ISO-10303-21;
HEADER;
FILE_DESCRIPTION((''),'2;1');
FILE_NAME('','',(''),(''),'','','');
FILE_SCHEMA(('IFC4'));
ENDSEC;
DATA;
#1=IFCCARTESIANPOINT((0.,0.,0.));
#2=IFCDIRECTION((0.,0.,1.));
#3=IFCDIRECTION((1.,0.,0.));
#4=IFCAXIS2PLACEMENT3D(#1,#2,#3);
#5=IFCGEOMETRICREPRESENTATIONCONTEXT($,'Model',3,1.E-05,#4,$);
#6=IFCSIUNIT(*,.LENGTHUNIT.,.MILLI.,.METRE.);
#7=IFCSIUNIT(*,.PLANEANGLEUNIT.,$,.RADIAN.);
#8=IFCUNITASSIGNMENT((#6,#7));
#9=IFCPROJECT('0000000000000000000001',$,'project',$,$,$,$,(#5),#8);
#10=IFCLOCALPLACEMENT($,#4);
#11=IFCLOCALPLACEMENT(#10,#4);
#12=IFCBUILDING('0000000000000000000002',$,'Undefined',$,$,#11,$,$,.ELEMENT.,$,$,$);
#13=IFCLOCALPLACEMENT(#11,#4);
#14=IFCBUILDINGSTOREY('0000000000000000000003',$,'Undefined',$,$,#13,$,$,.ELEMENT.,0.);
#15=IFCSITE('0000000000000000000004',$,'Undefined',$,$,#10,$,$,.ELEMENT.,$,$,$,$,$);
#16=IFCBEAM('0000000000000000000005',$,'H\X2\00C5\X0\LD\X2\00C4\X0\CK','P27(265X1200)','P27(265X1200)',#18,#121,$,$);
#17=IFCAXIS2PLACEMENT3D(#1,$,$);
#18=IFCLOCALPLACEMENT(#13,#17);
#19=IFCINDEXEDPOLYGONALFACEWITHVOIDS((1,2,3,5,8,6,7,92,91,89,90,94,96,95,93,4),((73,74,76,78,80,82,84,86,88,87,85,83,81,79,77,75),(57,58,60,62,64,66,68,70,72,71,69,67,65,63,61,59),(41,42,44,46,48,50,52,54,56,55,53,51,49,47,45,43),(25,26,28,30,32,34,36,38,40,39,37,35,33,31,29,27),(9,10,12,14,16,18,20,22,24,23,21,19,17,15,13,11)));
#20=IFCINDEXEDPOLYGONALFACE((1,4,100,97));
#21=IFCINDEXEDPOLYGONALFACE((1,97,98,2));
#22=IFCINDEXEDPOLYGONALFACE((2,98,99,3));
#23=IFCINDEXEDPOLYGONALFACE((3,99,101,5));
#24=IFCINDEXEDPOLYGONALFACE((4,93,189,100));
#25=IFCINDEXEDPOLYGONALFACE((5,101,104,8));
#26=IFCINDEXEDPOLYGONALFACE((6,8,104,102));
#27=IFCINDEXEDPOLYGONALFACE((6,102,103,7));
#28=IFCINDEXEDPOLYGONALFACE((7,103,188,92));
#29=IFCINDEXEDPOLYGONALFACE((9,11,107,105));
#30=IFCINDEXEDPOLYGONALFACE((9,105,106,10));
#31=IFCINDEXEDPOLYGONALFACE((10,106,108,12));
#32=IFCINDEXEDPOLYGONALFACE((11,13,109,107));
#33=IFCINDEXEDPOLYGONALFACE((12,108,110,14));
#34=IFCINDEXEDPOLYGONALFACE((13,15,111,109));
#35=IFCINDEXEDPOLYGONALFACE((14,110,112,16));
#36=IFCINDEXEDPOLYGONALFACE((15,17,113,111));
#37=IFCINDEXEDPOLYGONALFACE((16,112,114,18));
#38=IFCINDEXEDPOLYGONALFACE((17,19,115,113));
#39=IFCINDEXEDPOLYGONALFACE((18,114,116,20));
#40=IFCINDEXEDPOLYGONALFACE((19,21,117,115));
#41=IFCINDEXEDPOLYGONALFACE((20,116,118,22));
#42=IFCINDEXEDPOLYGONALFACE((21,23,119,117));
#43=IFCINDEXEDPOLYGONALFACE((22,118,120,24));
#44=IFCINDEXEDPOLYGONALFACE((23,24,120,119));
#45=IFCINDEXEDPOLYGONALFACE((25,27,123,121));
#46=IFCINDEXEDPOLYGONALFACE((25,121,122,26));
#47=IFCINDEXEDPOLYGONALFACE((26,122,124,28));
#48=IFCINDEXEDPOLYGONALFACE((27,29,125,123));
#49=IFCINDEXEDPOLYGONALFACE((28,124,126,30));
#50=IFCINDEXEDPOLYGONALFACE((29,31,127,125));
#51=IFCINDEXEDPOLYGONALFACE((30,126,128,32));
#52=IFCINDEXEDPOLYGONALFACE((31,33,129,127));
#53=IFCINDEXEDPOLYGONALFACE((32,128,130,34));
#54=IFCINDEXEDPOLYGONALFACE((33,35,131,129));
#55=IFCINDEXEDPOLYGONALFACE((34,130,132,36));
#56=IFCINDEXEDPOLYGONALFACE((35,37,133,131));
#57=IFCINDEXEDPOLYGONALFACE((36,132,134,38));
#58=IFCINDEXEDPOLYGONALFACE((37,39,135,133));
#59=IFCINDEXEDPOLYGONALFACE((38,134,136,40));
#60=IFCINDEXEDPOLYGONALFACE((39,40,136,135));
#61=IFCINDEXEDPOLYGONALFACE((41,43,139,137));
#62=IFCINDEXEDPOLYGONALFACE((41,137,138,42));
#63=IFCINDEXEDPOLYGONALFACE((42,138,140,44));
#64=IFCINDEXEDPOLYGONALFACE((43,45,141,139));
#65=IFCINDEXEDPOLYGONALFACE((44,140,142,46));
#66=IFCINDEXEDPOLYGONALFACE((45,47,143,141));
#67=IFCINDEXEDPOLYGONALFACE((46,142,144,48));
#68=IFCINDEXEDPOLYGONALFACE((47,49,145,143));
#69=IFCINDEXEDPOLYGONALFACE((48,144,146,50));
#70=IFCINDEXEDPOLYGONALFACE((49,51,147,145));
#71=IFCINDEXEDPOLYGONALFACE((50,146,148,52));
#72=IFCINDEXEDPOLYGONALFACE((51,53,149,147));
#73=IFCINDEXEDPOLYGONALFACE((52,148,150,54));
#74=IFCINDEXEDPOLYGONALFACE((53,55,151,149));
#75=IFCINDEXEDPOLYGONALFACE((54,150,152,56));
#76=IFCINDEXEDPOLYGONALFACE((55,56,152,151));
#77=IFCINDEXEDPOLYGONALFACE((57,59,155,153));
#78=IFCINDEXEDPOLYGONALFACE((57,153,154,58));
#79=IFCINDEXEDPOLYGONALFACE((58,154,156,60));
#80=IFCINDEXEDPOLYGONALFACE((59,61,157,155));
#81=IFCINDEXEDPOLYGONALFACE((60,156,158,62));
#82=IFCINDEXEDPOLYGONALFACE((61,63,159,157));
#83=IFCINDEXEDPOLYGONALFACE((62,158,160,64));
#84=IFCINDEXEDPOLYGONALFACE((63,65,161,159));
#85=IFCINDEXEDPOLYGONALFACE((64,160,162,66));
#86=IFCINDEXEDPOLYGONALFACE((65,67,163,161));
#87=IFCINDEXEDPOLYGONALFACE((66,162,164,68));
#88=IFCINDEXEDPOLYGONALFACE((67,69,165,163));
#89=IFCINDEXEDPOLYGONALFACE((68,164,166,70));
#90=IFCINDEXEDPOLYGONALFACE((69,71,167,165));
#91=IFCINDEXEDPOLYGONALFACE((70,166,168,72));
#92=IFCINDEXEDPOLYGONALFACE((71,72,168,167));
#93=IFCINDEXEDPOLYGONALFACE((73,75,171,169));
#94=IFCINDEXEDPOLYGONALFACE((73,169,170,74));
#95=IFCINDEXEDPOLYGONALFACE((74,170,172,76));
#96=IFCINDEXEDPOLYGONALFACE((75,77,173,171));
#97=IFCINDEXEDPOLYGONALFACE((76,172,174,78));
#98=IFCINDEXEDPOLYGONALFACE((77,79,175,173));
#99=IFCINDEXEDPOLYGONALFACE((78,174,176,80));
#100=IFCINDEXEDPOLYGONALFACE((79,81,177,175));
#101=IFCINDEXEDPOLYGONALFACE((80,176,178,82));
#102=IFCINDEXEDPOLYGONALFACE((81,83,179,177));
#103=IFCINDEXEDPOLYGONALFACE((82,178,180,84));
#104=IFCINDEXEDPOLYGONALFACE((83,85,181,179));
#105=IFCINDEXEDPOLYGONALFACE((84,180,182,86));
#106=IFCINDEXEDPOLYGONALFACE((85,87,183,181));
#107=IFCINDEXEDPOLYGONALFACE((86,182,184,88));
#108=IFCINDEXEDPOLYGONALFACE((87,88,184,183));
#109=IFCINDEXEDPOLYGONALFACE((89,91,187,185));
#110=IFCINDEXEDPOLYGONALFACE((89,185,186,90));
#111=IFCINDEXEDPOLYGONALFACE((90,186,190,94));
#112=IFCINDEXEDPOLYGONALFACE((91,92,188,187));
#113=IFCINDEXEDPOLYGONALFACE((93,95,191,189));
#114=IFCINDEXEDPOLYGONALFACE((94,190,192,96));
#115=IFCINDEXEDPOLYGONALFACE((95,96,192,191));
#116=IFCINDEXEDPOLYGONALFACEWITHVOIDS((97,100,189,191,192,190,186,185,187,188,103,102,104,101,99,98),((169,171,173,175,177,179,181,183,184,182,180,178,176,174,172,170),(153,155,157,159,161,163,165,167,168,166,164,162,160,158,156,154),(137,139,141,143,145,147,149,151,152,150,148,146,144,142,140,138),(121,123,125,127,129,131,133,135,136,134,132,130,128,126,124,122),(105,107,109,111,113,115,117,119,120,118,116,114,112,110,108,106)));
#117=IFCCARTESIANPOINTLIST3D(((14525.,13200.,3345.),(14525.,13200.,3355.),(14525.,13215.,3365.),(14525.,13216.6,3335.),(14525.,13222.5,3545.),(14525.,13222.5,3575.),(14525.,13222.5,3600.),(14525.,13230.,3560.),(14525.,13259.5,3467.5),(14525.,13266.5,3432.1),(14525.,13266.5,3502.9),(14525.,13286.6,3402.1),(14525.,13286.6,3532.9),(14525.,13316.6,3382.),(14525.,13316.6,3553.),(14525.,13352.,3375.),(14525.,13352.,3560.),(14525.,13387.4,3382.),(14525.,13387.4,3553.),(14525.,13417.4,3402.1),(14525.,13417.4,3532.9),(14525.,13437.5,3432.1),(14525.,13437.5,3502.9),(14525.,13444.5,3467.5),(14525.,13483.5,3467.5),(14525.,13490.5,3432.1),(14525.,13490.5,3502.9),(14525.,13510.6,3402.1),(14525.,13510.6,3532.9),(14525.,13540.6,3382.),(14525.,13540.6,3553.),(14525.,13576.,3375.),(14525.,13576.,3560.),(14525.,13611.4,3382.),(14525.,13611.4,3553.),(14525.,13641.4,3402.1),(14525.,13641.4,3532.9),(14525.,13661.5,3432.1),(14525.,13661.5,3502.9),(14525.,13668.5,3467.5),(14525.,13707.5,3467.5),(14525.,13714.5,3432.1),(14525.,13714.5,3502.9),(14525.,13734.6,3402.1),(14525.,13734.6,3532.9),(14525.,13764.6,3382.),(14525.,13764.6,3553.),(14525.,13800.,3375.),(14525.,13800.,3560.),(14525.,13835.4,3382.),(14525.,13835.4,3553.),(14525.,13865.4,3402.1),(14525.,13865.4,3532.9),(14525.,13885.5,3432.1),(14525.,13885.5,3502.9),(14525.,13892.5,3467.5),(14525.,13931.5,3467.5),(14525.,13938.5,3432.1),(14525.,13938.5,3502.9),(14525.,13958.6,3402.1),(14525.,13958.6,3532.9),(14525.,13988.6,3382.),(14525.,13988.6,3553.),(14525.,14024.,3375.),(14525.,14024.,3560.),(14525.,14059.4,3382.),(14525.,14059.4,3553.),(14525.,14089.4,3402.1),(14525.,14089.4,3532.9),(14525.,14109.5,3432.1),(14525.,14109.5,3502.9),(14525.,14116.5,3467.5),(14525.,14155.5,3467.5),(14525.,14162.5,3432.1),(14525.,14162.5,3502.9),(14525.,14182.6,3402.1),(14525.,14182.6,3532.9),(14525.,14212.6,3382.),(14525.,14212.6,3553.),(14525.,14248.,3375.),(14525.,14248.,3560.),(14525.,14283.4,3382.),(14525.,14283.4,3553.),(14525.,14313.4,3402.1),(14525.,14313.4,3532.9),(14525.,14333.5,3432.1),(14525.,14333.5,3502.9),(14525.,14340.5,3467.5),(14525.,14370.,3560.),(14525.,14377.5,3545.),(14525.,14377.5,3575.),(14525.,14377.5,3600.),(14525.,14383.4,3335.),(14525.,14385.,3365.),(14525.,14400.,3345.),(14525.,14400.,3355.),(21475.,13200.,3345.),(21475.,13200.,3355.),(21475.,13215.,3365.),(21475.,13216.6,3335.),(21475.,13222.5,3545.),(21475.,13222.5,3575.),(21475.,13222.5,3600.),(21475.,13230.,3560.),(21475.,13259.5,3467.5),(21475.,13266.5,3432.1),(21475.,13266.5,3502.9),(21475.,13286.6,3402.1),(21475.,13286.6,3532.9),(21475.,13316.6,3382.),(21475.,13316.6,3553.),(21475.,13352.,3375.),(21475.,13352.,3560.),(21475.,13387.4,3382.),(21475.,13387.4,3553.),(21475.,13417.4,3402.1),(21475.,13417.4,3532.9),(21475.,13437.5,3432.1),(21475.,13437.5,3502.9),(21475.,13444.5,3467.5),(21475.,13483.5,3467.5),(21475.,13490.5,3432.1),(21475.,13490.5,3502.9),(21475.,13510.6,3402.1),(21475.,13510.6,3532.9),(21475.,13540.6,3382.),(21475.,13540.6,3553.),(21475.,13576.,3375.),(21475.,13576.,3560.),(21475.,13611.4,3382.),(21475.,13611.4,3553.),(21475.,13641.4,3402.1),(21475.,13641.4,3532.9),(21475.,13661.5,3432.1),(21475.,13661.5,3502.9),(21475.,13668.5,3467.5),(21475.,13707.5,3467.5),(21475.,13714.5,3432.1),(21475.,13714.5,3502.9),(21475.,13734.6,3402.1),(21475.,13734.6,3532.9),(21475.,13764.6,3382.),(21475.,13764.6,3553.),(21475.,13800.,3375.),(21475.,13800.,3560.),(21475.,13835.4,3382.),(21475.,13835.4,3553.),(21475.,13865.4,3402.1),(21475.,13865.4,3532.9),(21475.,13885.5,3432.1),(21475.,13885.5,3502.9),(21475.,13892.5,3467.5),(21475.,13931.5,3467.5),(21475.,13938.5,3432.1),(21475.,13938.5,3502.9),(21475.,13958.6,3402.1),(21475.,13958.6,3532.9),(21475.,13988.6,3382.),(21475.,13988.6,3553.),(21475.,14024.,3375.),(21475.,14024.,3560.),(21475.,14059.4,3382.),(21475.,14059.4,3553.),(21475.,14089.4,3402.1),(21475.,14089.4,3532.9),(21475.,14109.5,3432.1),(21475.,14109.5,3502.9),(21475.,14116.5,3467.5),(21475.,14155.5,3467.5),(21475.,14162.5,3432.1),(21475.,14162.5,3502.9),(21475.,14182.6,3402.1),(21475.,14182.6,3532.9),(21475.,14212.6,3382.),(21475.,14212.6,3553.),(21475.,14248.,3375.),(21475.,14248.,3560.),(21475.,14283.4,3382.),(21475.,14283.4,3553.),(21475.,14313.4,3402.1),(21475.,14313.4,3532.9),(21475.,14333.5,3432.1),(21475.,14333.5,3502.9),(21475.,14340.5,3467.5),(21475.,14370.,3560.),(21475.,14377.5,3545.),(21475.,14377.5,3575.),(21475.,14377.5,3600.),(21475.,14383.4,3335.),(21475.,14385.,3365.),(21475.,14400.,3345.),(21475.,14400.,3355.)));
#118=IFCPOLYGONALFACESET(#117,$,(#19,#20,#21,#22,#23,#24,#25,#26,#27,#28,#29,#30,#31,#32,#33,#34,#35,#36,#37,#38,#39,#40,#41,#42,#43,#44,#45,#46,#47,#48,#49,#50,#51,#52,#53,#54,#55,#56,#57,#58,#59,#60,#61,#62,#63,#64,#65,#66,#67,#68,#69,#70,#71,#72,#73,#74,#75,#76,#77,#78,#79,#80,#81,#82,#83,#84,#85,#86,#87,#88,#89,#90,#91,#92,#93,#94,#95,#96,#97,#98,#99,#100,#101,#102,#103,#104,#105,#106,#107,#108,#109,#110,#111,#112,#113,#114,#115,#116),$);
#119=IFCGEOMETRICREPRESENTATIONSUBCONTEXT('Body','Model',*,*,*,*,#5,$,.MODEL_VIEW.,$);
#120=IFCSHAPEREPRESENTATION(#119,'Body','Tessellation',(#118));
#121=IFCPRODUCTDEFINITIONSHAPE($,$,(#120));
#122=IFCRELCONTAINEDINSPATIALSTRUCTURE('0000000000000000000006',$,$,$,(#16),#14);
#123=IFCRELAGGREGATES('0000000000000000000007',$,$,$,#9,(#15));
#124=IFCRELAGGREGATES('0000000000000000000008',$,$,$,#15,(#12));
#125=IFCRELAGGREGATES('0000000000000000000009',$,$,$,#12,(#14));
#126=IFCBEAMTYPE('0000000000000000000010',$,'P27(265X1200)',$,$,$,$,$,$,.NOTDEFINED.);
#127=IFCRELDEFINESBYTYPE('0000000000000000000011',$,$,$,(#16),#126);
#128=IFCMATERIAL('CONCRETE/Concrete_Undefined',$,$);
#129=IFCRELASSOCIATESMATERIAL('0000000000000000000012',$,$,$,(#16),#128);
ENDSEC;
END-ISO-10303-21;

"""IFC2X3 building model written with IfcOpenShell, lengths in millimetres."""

from ifc_helpers import new_model, si_unit, frame, origin_with_axes, place, context, subcontext, project, spatial, polyline, outline, extrude, material, type_object, element, save


model = new_model("IFC2X3")

# Units and contexts
model_context = context("Model", 3, precision=1e-05, world=origin_with_axes())
body_context = subcontext(model_context, "Body", "Model", "MODEL_VIEW")
ifc_project = project(units=[si_unit("LENGTHUNIT", "METRE", prefix="MILLI"), si_unit("PLANEANGLEUNIT", "RADIAN")], contexts=[model_context])

# Site, building, storey
site_placement = place(None, origin_with_axes())
site = spatial("IfcSite", under=ifc_project, at=site_placement, Name="Undefined", CompositionType="ELEMENT")
building_placement = place(site_placement, origin_with_axes())
building = spatial("IfcBuilding", under=site, at=building_placement, Name="Undefined", CompositionType="ELEMENT")
storey_placement = place(building_placement, origin_with_axes())
storey = spatial("IfcBuildingStorey", under=building, at=storey_placement, Name="Undefined", CompositionType="ELEMENT", Elevation=0.0)

# Beam
ifc_material_1 = material(Name="CONCRETE/Concrete_Undefined")
beam_type_1 = type_object("IfcBeamType", Name="P27(265X1200)", PredefinedType="NOTDEFINED")
beam_1_placement = place(storey_placement, frame((14525.0, 13800.0, 3467.5), z_axis=(0.0, 0.0, 1.0), x_axis=(1.0, 0.0, 0.0)))
element("IfcBeam", 1, at=beam_1_placement, inside=storey, type_object=beam_type_1, material=ifc_material_1, Name="HÅLDÄCK", Description="P27(265X1200)", ObjectType="P27(265X1200)", context=body_context, shape_type="SweptSolid", body=[
    extrude(outline(polyline([(-583.4, -132.5), (-600.0, -122.5), (-600.0, -112.5), (-585.0, -102.5), (-577.5, 77.5), (-570.0, 92.5), (-577.5, 107.5), (-577.5, 132.5), (577.5, 132.5), (577.5, 107.5), (570.0, 92.5), (577.5, 77.5), (585.0, -102.5), (600.0, -112.5), (600.0, -122.5), (583.4, -132.5), (-583.4, -132.5)]), holes=[polyline([(-513.4, 65.4), (-533.5, 35.4), (-540.5, 0.0), (-533.5, -35.4), (-513.4, -65.4), (-483.4, -85.5), (-448.0, -92.5), (-412.6, -85.5), (-382.6, -65.4), (-362.5, -35.4), (-355.5, 0.0), (-362.5, 35.4), (-382.6, 65.4), (-412.6, 85.5), (-448.0, 92.5), (-483.4, 85.5), (-513.4, 65.4)]), polyline([(-289.4, 65.4), (-309.5, 35.4), (-316.5, 0.0), (-309.5, -35.4), (-289.4, -65.4), (-259.4, -85.5), (-224.0, -92.5), (-188.6, -85.5), (-158.6, -65.4), (-138.5, -35.4), (-131.5, 0.0), (-138.5, 35.4), (-158.6, 65.4), (-188.6, 85.5), (-224.0, 92.5), (-259.4, 85.5), (-289.4, 65.4)]), polyline([(-65.4, 65.4), (-85.5, 35.4), (-92.5, 0.0), (-85.5, -35.4), (-65.4, -65.4), (-35.4, -85.5), (0.0, -92.5), (35.4, -85.5), (65.4, -65.4), (85.5, -35.4), (92.5, 0.0), (85.5, 35.4), (65.4, 65.4), (35.4, 85.5), (0.0, 92.5), (-35.4, 85.5), (-65.4, 65.4)]), polyline([(158.6, 65.4), (138.5, 35.4), (131.5, 0.0), (138.5, -35.4), (158.6, -65.4), (188.6, -85.5), (224.0, -92.5), (259.4, -85.5), (289.4, -65.4), (309.5, -35.4), (316.5, 0.0), (309.5, 35.4), (289.4, 65.4), (259.4, 85.5), (224.0, 92.5), (188.6, 85.5), (158.6, 65.4)]), polyline([(382.6, 65.4), (362.5, 35.4), (355.5, 0.0), (362.5, -35.4), (382.6, -65.4), (412.6, -85.5), (448.0, -92.5), (483.4, -85.5), (513.4, -65.4), (533.5, -35.4), (540.5, 0.0), (533.5, 35.4), (513.4, 65.4), (483.4, 85.5), (448.0, 92.5), (412.6, 85.5), (382.6, 65.4)])]), frame((6950.0, 0.0, 0.0), z_axis=(-1.0, 0.0, 0.0), x_axis=(0.0, -1.0, 0.0)), (0.0, 0.0, 1.0), 6950.0),
])

save(model, "model.ifc")
